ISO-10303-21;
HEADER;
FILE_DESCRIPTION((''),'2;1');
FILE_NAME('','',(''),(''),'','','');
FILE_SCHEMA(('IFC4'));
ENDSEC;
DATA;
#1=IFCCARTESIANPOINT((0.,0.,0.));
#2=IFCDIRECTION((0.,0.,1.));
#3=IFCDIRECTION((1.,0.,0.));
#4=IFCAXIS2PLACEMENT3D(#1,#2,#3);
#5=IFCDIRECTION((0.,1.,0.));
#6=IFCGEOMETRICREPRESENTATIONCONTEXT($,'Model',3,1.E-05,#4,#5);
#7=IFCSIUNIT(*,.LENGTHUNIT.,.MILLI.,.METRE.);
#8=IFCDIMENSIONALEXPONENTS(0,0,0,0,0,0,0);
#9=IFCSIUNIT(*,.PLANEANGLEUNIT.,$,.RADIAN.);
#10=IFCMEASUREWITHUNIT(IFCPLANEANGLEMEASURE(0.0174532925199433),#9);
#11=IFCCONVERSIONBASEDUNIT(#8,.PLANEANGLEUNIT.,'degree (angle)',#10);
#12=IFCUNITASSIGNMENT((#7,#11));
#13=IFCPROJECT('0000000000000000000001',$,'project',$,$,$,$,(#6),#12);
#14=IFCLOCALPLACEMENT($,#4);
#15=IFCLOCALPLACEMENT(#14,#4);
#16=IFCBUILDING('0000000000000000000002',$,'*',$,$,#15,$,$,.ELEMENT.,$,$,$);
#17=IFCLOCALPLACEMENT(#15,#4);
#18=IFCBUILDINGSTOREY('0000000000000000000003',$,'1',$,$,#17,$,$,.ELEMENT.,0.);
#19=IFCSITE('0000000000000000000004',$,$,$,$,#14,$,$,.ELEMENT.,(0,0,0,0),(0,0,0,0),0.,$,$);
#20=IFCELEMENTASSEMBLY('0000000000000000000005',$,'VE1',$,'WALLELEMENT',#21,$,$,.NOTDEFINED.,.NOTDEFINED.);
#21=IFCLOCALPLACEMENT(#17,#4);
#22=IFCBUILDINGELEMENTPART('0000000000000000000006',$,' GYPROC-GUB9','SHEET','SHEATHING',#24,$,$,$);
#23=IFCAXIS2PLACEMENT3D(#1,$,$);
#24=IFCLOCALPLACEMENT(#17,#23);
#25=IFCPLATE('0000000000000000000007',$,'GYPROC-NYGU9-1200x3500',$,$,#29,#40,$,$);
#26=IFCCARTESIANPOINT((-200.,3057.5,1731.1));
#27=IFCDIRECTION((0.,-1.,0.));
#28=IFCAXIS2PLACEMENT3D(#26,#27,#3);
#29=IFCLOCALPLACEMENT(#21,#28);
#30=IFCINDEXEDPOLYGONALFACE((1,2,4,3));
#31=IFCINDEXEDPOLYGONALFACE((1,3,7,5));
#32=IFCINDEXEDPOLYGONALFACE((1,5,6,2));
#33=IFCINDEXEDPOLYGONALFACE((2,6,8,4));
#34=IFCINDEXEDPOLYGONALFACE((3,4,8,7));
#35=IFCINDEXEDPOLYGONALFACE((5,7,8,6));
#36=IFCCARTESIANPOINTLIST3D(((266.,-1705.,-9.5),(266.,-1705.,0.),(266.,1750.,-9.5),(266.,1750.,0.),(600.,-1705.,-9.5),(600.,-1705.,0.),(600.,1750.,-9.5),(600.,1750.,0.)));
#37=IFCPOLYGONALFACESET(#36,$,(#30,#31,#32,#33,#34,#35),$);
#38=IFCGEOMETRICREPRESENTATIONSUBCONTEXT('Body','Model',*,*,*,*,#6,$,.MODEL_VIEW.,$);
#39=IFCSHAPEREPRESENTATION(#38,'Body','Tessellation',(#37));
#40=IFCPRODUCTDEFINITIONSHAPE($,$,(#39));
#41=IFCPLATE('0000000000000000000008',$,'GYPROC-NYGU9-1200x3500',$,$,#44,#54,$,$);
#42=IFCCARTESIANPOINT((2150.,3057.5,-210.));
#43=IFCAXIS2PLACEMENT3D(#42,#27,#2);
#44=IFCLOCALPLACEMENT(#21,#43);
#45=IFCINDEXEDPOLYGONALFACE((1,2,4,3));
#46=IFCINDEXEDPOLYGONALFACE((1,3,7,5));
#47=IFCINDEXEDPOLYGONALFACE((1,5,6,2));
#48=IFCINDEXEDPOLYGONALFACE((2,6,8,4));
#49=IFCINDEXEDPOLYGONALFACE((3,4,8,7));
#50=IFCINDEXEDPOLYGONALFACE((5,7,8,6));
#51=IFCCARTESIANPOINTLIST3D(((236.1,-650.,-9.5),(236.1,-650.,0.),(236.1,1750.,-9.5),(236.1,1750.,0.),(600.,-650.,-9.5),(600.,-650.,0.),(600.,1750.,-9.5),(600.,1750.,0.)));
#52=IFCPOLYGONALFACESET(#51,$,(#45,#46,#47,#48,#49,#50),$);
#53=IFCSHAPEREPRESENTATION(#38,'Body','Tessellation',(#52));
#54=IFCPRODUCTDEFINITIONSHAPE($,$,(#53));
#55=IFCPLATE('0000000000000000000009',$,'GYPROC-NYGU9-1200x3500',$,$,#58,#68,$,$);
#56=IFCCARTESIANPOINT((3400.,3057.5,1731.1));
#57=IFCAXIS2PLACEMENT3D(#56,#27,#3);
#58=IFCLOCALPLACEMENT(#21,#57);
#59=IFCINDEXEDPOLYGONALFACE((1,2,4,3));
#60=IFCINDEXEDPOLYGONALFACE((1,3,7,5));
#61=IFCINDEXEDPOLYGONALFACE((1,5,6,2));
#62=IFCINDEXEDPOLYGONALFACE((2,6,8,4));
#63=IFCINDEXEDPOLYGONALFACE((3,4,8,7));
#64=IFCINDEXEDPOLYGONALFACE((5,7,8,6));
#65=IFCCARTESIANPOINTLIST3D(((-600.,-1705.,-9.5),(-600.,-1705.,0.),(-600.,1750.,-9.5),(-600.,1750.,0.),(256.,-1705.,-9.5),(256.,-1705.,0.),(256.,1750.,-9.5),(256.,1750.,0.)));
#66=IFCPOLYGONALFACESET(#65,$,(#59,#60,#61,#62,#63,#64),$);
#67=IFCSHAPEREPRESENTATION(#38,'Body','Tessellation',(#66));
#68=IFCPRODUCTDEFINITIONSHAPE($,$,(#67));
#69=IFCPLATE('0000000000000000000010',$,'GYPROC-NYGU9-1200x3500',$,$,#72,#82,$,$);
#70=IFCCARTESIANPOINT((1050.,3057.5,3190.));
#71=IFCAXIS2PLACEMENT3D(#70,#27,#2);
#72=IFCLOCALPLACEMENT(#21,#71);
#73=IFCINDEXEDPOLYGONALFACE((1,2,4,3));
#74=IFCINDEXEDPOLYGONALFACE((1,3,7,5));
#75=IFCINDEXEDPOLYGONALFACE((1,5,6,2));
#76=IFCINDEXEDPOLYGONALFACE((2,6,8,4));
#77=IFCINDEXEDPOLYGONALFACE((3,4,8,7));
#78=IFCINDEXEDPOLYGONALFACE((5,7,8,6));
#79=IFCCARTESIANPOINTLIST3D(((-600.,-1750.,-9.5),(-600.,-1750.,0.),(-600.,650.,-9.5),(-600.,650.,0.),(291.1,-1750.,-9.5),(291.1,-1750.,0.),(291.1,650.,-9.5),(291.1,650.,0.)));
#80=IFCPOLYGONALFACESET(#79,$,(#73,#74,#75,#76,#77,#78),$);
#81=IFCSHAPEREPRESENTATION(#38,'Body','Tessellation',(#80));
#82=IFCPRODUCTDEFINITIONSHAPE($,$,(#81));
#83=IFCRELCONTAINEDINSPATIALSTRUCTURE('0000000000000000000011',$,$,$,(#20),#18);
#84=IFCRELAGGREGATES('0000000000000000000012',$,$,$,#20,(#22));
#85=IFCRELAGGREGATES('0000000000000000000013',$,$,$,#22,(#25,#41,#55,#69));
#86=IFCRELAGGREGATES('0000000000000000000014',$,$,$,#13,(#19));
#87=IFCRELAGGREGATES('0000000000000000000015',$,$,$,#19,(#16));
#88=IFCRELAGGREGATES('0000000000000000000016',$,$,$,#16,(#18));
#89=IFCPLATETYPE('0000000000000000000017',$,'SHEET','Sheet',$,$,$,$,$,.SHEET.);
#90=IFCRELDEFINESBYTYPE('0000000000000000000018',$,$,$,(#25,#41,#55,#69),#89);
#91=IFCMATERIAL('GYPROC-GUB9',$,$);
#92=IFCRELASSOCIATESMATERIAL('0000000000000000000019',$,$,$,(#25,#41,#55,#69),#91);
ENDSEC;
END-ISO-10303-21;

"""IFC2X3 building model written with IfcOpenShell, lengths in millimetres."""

from ifc_helpers import new_model, entity, si_unit, converted_unit, direction, frame, origin_with_axes, place, context, subcontext, project, spatial, polyline, segment, composite_curve, outline, extrude, material, type_object, element, aggregate, save


model = new_model("IFC2X3")

# Units and contexts
model_context = context("Model", 3, precision=1e-05, world=origin_with_axes(), true_north=direction((0.0, 1.0, 0.0)))
body_context = subcontext(model_context, "Body", "Model", "MODEL_VIEW")
ifc_project = project(units=[si_unit("LENGTHUNIT", "METRE", prefix="MILLI"), converted_unit("PLANEANGLEUNIT", "degree (angle)", entity("IfcPlaneAngleMeasure", 0.0174532925199433), si_unit("PLANEANGLEUNIT", "RADIAN"), dimensions=[0, 0, 0, 0, 0, 0, 0])], contexts=[model_context])

# Site, building, storey
site_placement = place(None, origin_with_axes())
site = spatial("IfcSite", under=ifc_project, at=site_placement, CompositionType="ELEMENT", RefLatitude=(0, 0, 0, 0), RefLongitude=(0, 0, 0, 0), RefElevation=0.0)
building_placement = place(site_placement, origin_with_axes())
building = spatial("IfcBuilding", under=site, at=building_placement, Name="*", CompositionType="ELEMENT")
storey_placement = place(building_placement, origin_with_axes())
storey = spatial("IfcBuildingStorey", under=building, at=storey_placement, Name="1", CompositionType="ELEMENT", Elevation=0.0)

# Element assembly, building element part, plates
assembly_placement = place(storey_placement, origin_with_axes())
assembly = element("IfcElementAssembly", 1, at=assembly_placement, inside=storey, Name="VE1", ObjectType="WALLELEMENT", AssemblyPlace="NOTDEFINED", PredefinedType="NOTDEFINED")
building_element_part_1 = element("IfcBuildingElementPart", 2, Name=" GYPROC-GUB9", Description="SHEET", ObjectType="SHEATHING")
aggregate(assembly, [building_element_part_1])
ifc_material_1 = material(Name="GYPROC-GUB9")
plate_type = type_object("IfcPlateType", Name="SHEET", Description="Sheet", PredefinedType="SHEET")
plate_1_placement = place(assembly_placement, frame((-200.0, 3057.5, 1731.1), z_axis=(0.0, -1.0, 0.0), x_axis=(1.0, 0.0, 0.0)))
plate_1 = element("IfcPlate", 3, at=plate_1_placement, type_object=plate_type, material=ifc_material_1, Name="GYPROC-NYGU9-1200x3500", context=body_context, shape_type="SweptSolid", body=[
    extrude(outline(composite_curve([segment(polyline([(-600.0, -9.5), (-266.0, -9.5), (-266.0, 0.0), (-600.0, 0.0), (-600.0, -9.5)]), True, "CONTINUOUS")], self_intersect=False)), frame((0.0, -1705.0, 0.0), z_axis=(0.0, 1.0, 0.0), x_axis=(-1.0, 0.0, 0.0)), (0.0, 0.0, 1.0), 3455.0),
])
plate_2_placement = place(assembly_placement, frame((2150.0, 3057.5, -210.0), z_axis=(0.0, -1.0, 0.0), x_axis=(0.0, 0.0, 1.0)))
plate_2 = element("IfcPlate", 4, at=plate_2_placement, type_object=plate_type, material=ifc_material_1, Name="GYPROC-NYGU9-1200x3500", context=body_context, shape_type="SweptSolid", body=[
    extrude(outline(composite_curve([segment(polyline([(-600.0, -9.5), (-236.1, -9.5), (-236.1, 0.0), (-600.0, 0.0), (-600.0, -9.5)]), True, "CONTINUOUS")], self_intersect=False)), frame((0.0, -650.0, 0.0), z_axis=(0.0, 1.0, 0.0), x_axis=(-1.0, 0.0, 0.0)), (0.0, 0.0, 1.0), 2400.0),
])
plate_3_placement = place(assembly_placement, frame((3400.0, 3057.5, 1731.1), z_axis=(0.0, -1.0, 0.0), x_axis=(1.0, 0.0, 0.0)))
plate_3 = element("IfcPlate", 5, at=plate_3_placement, type_object=plate_type, material=ifc_material_1, Name="GYPROC-NYGU9-1200x3500", context=body_context, shape_type="SweptSolid", body=[
    extrude(outline(composite_curve([segment(polyline([(-256.0, -9.5), (600.0, -9.5), (600.0, 0.0), (-256.0, 0.0), (-256.0, -9.5)]), True, "CONTINUOUS")], self_intersect=False)), frame((0.0, -1705.0, 0.0), z_axis=(0.0, 1.0, 0.0), x_axis=(-1.0, 0.0, 0.0)), (0.0, 0.0, 1.0), 3455.0),
])
plate_4_placement = place(assembly_placement, frame((1050.0, 3057.5, 3190.0), z_axis=(0.0, -1.0, 0.0), x_axis=(0.0, 0.0, 1.0)))
plate_4 = element("IfcPlate", 6, at=plate_4_placement, type_object=plate_type, material=ifc_material_1, Name="GYPROC-NYGU9-1200x3500", context=body_context, shape_type="SweptSolid", body=[
    extrude(outline(composite_curve([segment(polyline([(-291.1, -9.5), (600.0, -9.5), (600.0, 0.0), (-291.1, 0.0), (-291.1, -9.5)]), True, "CONTINUOUS")], self_intersect=False)), frame((0.0, -1750.0, 0.0), z_axis=(0.0, 1.0, 0.0), x_axis=(-1.0, 0.0, 0.0)), (0.0, 0.0, 1.0), 2400.0),
])
aggregate(building_element_part_1, [plate_1, plate_2, plate_3, plate_4])

save(model, "model.ifc")
